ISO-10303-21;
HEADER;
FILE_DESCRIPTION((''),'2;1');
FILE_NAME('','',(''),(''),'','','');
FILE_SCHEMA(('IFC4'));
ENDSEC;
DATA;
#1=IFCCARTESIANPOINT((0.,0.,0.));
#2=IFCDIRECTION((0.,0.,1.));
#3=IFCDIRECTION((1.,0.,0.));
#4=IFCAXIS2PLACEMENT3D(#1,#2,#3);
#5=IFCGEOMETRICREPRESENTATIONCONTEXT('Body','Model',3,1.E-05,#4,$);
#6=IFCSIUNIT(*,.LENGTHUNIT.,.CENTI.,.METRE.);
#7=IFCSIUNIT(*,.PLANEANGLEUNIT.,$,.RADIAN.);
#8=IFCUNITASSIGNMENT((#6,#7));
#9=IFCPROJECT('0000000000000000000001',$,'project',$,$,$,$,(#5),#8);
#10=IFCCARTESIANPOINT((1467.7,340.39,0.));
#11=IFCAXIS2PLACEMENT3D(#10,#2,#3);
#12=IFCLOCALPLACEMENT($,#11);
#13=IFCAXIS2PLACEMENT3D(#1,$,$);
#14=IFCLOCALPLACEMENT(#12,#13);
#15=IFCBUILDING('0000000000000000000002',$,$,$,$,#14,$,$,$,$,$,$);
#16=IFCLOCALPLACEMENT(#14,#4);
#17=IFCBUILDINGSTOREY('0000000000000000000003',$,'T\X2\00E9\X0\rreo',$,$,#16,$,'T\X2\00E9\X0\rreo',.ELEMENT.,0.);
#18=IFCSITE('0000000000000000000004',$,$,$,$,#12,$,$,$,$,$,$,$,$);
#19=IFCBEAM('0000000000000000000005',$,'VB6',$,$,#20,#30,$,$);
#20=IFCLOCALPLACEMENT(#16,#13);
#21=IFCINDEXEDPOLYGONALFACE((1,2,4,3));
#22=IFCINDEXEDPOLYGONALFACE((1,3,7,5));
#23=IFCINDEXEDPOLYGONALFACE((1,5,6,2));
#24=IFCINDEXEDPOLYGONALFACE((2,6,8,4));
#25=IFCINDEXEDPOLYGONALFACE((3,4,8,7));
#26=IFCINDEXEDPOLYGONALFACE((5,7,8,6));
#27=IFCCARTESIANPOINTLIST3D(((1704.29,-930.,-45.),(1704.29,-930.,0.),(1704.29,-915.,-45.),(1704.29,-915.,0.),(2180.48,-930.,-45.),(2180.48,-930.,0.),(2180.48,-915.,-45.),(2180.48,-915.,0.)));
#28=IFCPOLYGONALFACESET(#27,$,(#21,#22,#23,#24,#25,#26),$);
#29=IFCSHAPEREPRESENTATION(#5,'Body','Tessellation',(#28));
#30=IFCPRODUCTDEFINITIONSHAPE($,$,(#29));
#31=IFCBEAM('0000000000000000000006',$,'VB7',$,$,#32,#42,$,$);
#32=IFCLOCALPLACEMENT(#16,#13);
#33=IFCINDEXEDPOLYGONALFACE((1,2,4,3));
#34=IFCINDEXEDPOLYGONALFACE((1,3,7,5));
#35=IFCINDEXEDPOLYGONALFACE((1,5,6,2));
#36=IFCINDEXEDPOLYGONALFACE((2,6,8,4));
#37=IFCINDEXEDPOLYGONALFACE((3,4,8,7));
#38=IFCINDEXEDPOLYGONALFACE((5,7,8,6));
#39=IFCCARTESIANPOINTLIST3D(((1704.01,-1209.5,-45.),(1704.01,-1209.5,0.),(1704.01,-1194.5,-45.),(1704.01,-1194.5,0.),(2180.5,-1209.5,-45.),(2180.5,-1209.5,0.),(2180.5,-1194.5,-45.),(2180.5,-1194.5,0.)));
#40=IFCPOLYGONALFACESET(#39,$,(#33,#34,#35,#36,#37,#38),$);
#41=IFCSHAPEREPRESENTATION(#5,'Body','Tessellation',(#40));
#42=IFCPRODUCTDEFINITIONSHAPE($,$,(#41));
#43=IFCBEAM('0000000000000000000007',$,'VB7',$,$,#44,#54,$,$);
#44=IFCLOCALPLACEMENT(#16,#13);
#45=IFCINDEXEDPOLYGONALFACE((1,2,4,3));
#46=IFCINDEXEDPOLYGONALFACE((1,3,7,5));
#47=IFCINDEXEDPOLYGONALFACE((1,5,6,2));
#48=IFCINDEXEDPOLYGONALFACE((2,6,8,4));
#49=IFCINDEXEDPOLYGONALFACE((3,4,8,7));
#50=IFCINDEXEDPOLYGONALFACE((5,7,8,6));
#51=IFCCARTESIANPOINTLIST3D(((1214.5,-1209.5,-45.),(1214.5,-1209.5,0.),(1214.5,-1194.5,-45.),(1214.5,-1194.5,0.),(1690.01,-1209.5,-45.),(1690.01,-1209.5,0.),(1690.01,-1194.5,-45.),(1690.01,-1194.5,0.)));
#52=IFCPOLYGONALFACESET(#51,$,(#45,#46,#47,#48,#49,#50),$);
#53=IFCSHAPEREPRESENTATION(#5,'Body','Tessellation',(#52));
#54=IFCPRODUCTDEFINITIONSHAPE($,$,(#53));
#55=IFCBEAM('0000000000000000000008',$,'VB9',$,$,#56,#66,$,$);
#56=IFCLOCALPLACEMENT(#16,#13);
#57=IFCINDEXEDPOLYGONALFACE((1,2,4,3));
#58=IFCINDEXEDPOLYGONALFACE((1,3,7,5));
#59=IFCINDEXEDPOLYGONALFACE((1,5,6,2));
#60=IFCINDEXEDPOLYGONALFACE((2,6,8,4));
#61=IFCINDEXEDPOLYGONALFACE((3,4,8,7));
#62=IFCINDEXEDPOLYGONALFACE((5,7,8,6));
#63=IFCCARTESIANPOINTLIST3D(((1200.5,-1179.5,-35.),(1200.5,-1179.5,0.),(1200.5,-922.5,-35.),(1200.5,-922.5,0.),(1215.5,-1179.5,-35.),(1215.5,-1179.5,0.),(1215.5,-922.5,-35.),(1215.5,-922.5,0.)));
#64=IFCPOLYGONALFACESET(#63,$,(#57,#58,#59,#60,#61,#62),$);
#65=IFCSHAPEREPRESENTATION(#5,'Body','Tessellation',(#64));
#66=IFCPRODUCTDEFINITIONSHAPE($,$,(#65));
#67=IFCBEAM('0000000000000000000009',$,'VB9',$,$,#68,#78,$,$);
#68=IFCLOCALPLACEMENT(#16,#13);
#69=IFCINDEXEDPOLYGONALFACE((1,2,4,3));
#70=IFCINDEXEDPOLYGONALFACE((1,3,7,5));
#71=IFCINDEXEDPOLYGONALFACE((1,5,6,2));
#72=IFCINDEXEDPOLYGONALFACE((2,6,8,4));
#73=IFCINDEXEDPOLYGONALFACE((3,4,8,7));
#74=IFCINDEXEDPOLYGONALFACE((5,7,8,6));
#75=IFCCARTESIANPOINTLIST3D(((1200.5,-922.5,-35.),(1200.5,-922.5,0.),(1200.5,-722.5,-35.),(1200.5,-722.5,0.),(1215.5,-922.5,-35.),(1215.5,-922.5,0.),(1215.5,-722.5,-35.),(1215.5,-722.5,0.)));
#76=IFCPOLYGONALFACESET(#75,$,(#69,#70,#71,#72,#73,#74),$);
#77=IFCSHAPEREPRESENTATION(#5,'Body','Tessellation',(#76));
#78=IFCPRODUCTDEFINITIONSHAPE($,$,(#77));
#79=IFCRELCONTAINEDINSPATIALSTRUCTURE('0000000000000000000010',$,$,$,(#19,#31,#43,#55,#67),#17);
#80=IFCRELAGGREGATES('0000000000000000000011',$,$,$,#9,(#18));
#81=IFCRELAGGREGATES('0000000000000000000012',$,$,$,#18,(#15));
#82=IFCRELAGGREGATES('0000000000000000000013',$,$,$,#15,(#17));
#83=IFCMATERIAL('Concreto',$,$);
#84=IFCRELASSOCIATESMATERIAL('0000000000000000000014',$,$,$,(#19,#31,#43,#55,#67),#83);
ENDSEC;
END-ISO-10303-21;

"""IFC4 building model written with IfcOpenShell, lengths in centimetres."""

from ifc_helpers import new_model, si_unit, frame, origin, origin_with_axes, origin_2d_with_axis, place, context, project, spatial, rectangle, extrude, material, element, save


model = new_model("IFC4")

# Units and contexts
model_context = context("Model", 3, precision=1e-05, world=origin_with_axes(), identifier="Body")
ifc_project = project(units=[si_unit("LENGTHUNIT", "METRE", prefix="CENTI"), si_unit("PLANEANGLEUNIT", "RADIAN")], contexts=[model_context])

# Site, building, storey
site_placement = place(None, frame((1467.7, 340.39, 0.0), z_axis=(0.0, 0.0, 1.0), x_axis=(1.0, 0.0, 0.0)))
site = spatial("IfcSite", under=ifc_project, at=site_placement)
building_placement = place(site_placement, origin())
building = spatial("IfcBuilding", under=site, at=building_placement)
storey_placement = place(building_placement, origin_with_axes())
storey = spatial("IfcBuildingStorey", under=building, at=storey_placement, Name="Térreo", LongName="Térreo", CompositionType="ELEMENT", Elevation=0.0)

# Shared definitions
ifc_material = material(Name="Concreto")

# Beams
beam_1_placement = place(storey_placement, frame((1942.38, -922.5, 0.0), z_axis=(0.0, 0.0, 1.0), x_axis=(1.0, 0.0, 0.0)))
element("IfcBeam", 1, at=beam_1_placement, inside=storey, material=ifc_material, Name="VB6", context=model_context, shape_type="SolidModel", body=[
    extrude(rectangle(XDim=15.0, YDim=45.0, at=origin_2d_with_axis()), frame((-238.09, 0.0, -22.5), z_axis=(1.0, 0.0, 0.0), x_axis=(0.0, 1.0, 0.0)), (0.0, 0.0, 1.0), 476.19),
])
beam_2_placement = place(storey_placement, frame((1942.26, -1202.0, 0.0), z_axis=(0.0, 0.0, 1.0), x_axis=(1.0, 0.0, 0.0)))
element("IfcBeam", 2, at=beam_2_placement, inside=storey, material=ifc_material, Name="VB7", context=model_context, shape_type="SolidModel", body=[
    extrude(rectangle(XDim=15.0, YDim=45.0, at=origin_2d_with_axis()), frame((-238.25, 0.0, -22.5), z_axis=(1.0, 0.0, 0.0), x_axis=(0.0, -1.0, 0.0)), (0.0, 0.0, 1.0), 476.49),
])
beam_3_placement = place(storey_placement, frame((1452.26, -1202.0, 0.0), z_axis=(0.0, 0.0, 1.0), x_axis=(1.0, 0.0, 0.0)))
element("IfcBeam", 3, at=beam_3_placement, inside=storey, material=ifc_material, Name="VB7", context=model_context, shape_type="SolidModel", body=[
    extrude(rectangle(XDim=15.0, YDim=45.0, at=origin_2d_with_axis()), frame((-237.75, 0.0, -22.5), z_axis=(1.0, 0.0, 0.0), x_axis=(0.0, -1.0, 0.0)), (0.0, 0.0, 1.0), 475.51),
])
beam_4_placement = place(storey_placement, frame((1208.0, -1051.0, 0.0), z_axis=(0.0, 0.0, 1.0), x_axis=(1.0, 0.0, 0.0)))
element("IfcBeam", 4, at=beam_4_placement, inside=storey, material=ifc_material, Name="VB9", context=model_context, shape_type="SolidModel", body=[
    extrude(rectangle(XDim=15.0, YDim=35.0, at=origin_2d_with_axis()), frame((0.0, -128.5, -17.5), z_axis=(0.0, 1.0, 0.0), x_axis=(1.0, 0.0, 0.0)), (0.0, 0.0, 1.0), 257.0),
])
beam_5_placement = place(storey_placement, frame((1208.0, -822.5, 0.0), z_axis=(0.0, 0.0, 1.0), x_axis=(1.0, 0.0, 0.0)))
element("IfcBeam", 5, at=beam_5_placement, inside=storey, material=ifc_material, Name="VB9", context=model_context, shape_type="SolidModel", body=[
    extrude(rectangle(XDim=15.0, YDim=35.0, at=origin_2d_with_axis()), frame((0.0, -100.0, -17.5), z_axis=(0.0, 1.0, 0.0), x_axis=(1.0, 0.0, 0.0)), (0.0, 0.0, 1.0), 200.0),
])

save(model, "model.ifc")
